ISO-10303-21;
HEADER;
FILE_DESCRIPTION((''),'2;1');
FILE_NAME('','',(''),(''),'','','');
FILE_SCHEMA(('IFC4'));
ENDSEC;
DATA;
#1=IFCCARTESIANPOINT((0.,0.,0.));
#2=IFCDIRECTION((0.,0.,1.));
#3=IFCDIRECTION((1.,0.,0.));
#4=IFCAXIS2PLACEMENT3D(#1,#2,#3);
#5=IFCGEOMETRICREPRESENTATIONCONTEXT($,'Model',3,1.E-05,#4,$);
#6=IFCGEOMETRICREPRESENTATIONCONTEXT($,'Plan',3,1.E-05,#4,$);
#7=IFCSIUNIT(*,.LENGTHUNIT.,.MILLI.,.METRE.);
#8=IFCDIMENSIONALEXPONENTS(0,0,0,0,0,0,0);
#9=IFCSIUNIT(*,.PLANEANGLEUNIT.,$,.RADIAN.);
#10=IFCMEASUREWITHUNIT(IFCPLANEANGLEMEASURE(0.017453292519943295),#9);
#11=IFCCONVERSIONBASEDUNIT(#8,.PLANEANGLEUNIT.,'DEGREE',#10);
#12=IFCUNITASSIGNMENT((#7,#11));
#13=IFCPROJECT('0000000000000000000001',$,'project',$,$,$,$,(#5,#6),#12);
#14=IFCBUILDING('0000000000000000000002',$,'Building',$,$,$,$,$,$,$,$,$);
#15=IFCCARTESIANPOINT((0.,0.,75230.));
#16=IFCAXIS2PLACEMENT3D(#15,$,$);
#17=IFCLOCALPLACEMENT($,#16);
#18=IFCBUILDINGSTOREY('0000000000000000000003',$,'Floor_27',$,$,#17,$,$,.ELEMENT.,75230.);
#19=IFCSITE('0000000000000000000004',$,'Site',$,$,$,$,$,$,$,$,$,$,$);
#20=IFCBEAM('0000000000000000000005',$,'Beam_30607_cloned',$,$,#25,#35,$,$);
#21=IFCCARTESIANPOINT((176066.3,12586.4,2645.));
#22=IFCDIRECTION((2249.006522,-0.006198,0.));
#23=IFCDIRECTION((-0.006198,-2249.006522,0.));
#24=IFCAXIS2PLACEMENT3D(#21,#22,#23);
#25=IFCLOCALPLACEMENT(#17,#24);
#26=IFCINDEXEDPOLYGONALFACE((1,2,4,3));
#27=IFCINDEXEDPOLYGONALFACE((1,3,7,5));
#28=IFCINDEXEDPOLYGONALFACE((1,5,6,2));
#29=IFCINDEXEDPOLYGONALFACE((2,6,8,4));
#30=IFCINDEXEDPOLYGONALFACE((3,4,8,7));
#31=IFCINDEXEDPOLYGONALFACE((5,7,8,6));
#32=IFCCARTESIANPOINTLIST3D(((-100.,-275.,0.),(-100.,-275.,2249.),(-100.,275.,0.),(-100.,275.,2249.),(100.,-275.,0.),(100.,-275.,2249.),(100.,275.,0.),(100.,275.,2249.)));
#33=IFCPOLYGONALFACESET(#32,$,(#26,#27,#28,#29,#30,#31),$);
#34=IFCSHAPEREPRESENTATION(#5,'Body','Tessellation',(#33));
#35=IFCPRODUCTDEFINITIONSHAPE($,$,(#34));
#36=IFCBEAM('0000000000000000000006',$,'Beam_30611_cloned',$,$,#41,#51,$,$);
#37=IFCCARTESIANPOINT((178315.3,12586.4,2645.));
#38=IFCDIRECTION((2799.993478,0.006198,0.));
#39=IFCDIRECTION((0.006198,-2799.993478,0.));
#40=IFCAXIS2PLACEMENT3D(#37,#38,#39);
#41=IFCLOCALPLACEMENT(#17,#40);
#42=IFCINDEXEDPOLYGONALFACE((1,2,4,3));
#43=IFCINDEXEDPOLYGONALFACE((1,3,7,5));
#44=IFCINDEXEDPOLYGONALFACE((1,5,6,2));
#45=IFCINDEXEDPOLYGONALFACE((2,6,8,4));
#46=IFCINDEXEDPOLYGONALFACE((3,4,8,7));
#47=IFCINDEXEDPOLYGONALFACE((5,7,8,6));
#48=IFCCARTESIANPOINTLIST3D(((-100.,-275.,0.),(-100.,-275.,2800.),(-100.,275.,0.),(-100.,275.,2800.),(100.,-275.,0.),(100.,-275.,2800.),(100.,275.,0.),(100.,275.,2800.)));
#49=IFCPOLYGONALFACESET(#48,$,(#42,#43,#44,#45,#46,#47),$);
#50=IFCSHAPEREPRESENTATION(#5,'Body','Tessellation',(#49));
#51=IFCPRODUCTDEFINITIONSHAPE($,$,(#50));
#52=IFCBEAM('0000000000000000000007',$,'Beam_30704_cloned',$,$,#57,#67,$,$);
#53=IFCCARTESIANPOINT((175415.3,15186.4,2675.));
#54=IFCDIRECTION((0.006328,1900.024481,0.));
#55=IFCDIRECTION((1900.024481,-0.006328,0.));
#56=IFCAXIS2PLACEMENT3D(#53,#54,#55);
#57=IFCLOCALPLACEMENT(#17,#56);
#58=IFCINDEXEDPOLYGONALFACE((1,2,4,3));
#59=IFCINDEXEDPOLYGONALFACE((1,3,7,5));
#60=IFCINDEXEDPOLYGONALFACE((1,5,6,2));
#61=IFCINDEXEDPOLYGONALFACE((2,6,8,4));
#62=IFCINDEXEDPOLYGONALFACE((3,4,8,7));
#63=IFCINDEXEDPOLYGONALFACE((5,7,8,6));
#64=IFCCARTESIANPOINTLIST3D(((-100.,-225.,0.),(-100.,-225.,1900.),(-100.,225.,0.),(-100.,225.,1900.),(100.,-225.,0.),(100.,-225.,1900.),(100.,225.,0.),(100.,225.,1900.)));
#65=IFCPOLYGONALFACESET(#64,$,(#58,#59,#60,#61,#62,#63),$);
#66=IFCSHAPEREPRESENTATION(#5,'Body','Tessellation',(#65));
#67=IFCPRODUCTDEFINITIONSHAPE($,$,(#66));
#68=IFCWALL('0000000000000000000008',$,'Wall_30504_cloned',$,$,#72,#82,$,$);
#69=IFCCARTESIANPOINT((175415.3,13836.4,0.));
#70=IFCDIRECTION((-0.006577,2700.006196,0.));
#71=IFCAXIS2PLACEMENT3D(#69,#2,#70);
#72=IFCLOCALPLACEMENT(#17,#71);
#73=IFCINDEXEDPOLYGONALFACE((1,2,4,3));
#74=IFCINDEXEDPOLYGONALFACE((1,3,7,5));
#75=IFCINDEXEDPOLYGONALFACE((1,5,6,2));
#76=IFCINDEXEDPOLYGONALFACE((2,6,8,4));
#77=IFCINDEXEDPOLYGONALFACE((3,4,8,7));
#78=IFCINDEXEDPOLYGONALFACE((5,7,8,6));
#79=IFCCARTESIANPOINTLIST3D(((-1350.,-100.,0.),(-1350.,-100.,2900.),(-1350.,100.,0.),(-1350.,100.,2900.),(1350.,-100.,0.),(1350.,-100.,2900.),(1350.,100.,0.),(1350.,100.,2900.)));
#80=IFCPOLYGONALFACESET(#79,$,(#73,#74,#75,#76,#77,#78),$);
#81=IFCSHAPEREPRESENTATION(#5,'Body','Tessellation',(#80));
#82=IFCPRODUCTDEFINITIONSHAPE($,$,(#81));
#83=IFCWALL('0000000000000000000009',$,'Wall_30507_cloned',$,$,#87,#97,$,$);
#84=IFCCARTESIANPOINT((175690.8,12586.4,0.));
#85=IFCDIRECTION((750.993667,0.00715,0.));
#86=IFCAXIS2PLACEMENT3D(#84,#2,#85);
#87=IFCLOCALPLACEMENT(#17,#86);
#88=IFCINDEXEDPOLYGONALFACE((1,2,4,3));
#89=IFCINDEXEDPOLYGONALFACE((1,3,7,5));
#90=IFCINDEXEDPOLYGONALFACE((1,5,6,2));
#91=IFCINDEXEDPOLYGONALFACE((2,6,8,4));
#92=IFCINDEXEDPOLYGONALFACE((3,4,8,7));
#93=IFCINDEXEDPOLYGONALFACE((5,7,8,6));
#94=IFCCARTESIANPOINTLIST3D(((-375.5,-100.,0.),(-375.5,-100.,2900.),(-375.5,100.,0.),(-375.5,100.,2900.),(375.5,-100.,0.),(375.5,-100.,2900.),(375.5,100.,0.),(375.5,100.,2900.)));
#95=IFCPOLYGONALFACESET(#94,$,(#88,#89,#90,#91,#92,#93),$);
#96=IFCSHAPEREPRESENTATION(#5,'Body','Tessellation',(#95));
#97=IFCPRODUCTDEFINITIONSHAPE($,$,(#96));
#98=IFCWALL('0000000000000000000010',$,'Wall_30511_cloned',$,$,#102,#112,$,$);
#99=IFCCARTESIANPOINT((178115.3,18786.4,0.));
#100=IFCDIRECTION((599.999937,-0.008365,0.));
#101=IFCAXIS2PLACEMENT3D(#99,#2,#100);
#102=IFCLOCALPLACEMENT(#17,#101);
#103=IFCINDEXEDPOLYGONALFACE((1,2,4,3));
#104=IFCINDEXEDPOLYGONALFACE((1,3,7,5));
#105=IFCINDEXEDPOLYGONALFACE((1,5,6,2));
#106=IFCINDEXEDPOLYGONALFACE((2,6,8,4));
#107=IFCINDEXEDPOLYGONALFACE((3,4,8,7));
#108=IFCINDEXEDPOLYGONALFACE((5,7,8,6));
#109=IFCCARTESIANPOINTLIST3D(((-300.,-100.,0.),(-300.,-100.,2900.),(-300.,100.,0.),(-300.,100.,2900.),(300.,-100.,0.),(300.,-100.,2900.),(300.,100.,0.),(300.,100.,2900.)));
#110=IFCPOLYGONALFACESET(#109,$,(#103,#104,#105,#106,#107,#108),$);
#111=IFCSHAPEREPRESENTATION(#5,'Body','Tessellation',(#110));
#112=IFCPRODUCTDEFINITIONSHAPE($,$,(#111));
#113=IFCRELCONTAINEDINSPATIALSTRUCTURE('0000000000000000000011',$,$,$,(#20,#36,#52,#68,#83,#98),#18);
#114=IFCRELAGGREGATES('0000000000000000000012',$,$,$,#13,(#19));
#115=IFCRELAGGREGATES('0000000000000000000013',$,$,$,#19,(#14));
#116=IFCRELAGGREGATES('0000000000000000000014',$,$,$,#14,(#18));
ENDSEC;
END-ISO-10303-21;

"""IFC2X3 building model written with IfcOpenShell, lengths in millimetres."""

from ifc_helpers import new_model, entity, si_unit, converted_unit, frame, origin_with_axes, origin_2d, place, context, project, spatial, rectangle, extrude, source, transform, mapped, element, save


model = new_model("IFC2X3")

# Units and contexts
model_context = context("Model", 3, precision=1e-05, world=origin_with_axes())
plan_context = context("Plan", 3, precision=1e-05, world=origin_with_axes())
ifc_project = project(units=[si_unit("LENGTHUNIT", "METRE", prefix="MILLI"), converted_unit("PLANEANGLEUNIT", "DEGREE", entity("IfcPlaneAngleMeasure", 0.017453292519943295), si_unit("PLANEANGLEUNIT", "RADIAN"), dimensions=[0, 0, 0, 0, 0, 0, 0])], contexts=[model_context, plan_context])

# Site, building, storey
site = spatial("IfcSite", under=ifc_project, Name="Site")
building = spatial("IfcBuilding", under=site, Name="Building")
storey_placement = place(None, frame((0.0, 0.0, 75230.0)))
storey = spatial("IfcBuildingStorey", under=building, at=storey_placement, Name="Floor_27", CompositionType="ELEMENT", Elevation=75230.0)

# Beams
shared_shape_1 = source(origin_with_axes(), model_context, "Body", "SweptSolid", [
    extrude(rectangle(XDim=200.0, YDim=550.0, at=origin_2d()), origin_with_axes(), (0.0, 0.0, 1.0), 2249.0),
])
beam_1_placement = place(storey_placement, frame((176066.3, 12586.4, 2645.0), z_axis=(2249.006522, -0.006198, 0.0), x_axis=(-0.006198, -2249.006522, 0.0)))
element("IfcBeam", 1, at=beam_1_placement, inside=storey, Name="Beam_30607_cloned", context=model_context, shape_type="MappedRepresentation", body=[
    mapped(shared_shape_1, transform((0.0, 0.0, 0.0), x_axis=(1.0, 0.0, 0.0), y_axis=(0.0, 1.0, 0.0), z_axis=(0.0, 0.0, 1.0), scale=1.0)),
])
shared_shape_2 = source(origin_with_axes(), model_context, "Body", "SweptSolid", [
    extrude(rectangle(XDim=200.0, YDim=550.0, at=origin_2d()), origin_with_axes(), (0.0, 0.0, 1.0), 2800.0),
])
beam_2_placement = place(storey_placement, frame((178315.3, 12586.4, 2645.0), z_axis=(2799.993478, 0.006198, 0.0), x_axis=(0.006198, -2799.993478, 0.0)))
element("IfcBeam", 2, at=beam_2_placement, inside=storey, Name="Beam_30611_cloned", context=model_context, shape_type="MappedRepresentation", body=[
    mapped(shared_shape_2, transform((0.0, 0.0, 0.0), x_axis=(1.0, 0.0, 0.0), y_axis=(0.0, 1.0, 0.0), z_axis=(0.0, 0.0, 1.0), scale=1.0)),
])
shared_shape_3 = source(origin_with_axes(), model_context, "Body", "SweptSolid", [
    extrude(rectangle(XDim=200.0, YDim=450.0, at=origin_2d()), origin_with_axes(), (0.0, 0.0, 1.0), 1900.0),
])
beam_3_placement = place(storey_placement, frame((175415.3, 15186.4, 2675.0), z_axis=(0.006328, 1900.024481, 0.0), x_axis=(1900.024481, -0.006328, 0.0)))
element("IfcBeam", 3, at=beam_3_placement, inside=storey, Name="Beam_30704_cloned", context=model_context, shape_type="MappedRepresentation", body=[
    mapped(shared_shape_3, transform((0.0, 0.0, 0.0), x_axis=(1.0, 0.0, 0.0), y_axis=(0.0, 1.0, 0.0), z_axis=(0.0, 0.0, 1.0), scale=1.0)),
])

# Walls
shared_shape_4 = source(origin_with_axes(), model_context, "Body", "SweptSolid", [
    extrude(rectangle(XDim=2700.0, YDim=200.0, at=origin_2d()), origin_with_axes(), (0.0, 0.0, 1.0), 2900.0),
])
wall_1_placement = place(storey_placement, frame((175415.3, 13836.4, 0.0), z_axis=(0.0, 0.0, 1.0), x_axis=(-0.006577, 2700.006196, 0.0)))
element("IfcWall", 4, at=wall_1_placement, inside=storey, Name="Wall_30504_cloned", context=model_context, shape_type="MappedRepresentation", body=[
    mapped(shared_shape_4, transform((0.0, 0.0, 0.0), x_axis=(1.0, 0.0, 0.0), y_axis=(0.0, 1.0, 0.0), z_axis=(0.0, 0.0, 1.0), scale=1.0)),
])
shared_shape_5 = source(origin_with_axes(), model_context, "Body", "SweptSolid", [
    extrude(rectangle(XDim=751.0, YDim=200.0, at=origin_2d()), origin_with_axes(), (0.0, 0.0, 1.0), 2900.0),
])
wall_2_placement = place(storey_placement, frame((175690.8, 12586.4, 0.0), z_axis=(0.0, 0.0, 1.0), x_axis=(750.993667, 0.00715, 0.0)))
element("IfcWall", 5, at=wall_2_placement, inside=storey, Name="Wall_30507_cloned", context=model_context, shape_type="MappedRepresentation", body=[
    mapped(shared_shape_5, transform((0.0, 0.0, 0.0), x_axis=(1.0, 0.0, 0.0), y_axis=(0.0, 1.0, 0.0), z_axis=(0.0, 0.0, 1.0), scale=1.0)),
])
shared_shape_6 = source(origin_with_axes(), model_context, "Body", "SweptSolid", [
    extrude(rectangle(XDim=600.0, YDim=200.0, at=origin_2d()), origin_with_axes(), (0.0, 0.0, 1.0), 2900.0),
])
wall_3_placement = place(storey_placement, frame((178115.3, 18786.4, 0.0), z_axis=(0.0, 0.0, 1.0), x_axis=(599.999937, -0.008365, 0.0)))
element("IfcWall", 6, at=wall_3_placement, inside=storey, Name="Wall_30511_cloned", context=model_context, shape_type="MappedRepresentation", body=[
    mapped(shared_shape_6, transform((0.0, 0.0, 0.0), x_axis=(1.0, 0.0, 0.0), y_axis=(0.0, 1.0, 0.0), z_axis=(0.0, 0.0, 1.0), scale=1.0)),
])

save(model, "model.ifc")
